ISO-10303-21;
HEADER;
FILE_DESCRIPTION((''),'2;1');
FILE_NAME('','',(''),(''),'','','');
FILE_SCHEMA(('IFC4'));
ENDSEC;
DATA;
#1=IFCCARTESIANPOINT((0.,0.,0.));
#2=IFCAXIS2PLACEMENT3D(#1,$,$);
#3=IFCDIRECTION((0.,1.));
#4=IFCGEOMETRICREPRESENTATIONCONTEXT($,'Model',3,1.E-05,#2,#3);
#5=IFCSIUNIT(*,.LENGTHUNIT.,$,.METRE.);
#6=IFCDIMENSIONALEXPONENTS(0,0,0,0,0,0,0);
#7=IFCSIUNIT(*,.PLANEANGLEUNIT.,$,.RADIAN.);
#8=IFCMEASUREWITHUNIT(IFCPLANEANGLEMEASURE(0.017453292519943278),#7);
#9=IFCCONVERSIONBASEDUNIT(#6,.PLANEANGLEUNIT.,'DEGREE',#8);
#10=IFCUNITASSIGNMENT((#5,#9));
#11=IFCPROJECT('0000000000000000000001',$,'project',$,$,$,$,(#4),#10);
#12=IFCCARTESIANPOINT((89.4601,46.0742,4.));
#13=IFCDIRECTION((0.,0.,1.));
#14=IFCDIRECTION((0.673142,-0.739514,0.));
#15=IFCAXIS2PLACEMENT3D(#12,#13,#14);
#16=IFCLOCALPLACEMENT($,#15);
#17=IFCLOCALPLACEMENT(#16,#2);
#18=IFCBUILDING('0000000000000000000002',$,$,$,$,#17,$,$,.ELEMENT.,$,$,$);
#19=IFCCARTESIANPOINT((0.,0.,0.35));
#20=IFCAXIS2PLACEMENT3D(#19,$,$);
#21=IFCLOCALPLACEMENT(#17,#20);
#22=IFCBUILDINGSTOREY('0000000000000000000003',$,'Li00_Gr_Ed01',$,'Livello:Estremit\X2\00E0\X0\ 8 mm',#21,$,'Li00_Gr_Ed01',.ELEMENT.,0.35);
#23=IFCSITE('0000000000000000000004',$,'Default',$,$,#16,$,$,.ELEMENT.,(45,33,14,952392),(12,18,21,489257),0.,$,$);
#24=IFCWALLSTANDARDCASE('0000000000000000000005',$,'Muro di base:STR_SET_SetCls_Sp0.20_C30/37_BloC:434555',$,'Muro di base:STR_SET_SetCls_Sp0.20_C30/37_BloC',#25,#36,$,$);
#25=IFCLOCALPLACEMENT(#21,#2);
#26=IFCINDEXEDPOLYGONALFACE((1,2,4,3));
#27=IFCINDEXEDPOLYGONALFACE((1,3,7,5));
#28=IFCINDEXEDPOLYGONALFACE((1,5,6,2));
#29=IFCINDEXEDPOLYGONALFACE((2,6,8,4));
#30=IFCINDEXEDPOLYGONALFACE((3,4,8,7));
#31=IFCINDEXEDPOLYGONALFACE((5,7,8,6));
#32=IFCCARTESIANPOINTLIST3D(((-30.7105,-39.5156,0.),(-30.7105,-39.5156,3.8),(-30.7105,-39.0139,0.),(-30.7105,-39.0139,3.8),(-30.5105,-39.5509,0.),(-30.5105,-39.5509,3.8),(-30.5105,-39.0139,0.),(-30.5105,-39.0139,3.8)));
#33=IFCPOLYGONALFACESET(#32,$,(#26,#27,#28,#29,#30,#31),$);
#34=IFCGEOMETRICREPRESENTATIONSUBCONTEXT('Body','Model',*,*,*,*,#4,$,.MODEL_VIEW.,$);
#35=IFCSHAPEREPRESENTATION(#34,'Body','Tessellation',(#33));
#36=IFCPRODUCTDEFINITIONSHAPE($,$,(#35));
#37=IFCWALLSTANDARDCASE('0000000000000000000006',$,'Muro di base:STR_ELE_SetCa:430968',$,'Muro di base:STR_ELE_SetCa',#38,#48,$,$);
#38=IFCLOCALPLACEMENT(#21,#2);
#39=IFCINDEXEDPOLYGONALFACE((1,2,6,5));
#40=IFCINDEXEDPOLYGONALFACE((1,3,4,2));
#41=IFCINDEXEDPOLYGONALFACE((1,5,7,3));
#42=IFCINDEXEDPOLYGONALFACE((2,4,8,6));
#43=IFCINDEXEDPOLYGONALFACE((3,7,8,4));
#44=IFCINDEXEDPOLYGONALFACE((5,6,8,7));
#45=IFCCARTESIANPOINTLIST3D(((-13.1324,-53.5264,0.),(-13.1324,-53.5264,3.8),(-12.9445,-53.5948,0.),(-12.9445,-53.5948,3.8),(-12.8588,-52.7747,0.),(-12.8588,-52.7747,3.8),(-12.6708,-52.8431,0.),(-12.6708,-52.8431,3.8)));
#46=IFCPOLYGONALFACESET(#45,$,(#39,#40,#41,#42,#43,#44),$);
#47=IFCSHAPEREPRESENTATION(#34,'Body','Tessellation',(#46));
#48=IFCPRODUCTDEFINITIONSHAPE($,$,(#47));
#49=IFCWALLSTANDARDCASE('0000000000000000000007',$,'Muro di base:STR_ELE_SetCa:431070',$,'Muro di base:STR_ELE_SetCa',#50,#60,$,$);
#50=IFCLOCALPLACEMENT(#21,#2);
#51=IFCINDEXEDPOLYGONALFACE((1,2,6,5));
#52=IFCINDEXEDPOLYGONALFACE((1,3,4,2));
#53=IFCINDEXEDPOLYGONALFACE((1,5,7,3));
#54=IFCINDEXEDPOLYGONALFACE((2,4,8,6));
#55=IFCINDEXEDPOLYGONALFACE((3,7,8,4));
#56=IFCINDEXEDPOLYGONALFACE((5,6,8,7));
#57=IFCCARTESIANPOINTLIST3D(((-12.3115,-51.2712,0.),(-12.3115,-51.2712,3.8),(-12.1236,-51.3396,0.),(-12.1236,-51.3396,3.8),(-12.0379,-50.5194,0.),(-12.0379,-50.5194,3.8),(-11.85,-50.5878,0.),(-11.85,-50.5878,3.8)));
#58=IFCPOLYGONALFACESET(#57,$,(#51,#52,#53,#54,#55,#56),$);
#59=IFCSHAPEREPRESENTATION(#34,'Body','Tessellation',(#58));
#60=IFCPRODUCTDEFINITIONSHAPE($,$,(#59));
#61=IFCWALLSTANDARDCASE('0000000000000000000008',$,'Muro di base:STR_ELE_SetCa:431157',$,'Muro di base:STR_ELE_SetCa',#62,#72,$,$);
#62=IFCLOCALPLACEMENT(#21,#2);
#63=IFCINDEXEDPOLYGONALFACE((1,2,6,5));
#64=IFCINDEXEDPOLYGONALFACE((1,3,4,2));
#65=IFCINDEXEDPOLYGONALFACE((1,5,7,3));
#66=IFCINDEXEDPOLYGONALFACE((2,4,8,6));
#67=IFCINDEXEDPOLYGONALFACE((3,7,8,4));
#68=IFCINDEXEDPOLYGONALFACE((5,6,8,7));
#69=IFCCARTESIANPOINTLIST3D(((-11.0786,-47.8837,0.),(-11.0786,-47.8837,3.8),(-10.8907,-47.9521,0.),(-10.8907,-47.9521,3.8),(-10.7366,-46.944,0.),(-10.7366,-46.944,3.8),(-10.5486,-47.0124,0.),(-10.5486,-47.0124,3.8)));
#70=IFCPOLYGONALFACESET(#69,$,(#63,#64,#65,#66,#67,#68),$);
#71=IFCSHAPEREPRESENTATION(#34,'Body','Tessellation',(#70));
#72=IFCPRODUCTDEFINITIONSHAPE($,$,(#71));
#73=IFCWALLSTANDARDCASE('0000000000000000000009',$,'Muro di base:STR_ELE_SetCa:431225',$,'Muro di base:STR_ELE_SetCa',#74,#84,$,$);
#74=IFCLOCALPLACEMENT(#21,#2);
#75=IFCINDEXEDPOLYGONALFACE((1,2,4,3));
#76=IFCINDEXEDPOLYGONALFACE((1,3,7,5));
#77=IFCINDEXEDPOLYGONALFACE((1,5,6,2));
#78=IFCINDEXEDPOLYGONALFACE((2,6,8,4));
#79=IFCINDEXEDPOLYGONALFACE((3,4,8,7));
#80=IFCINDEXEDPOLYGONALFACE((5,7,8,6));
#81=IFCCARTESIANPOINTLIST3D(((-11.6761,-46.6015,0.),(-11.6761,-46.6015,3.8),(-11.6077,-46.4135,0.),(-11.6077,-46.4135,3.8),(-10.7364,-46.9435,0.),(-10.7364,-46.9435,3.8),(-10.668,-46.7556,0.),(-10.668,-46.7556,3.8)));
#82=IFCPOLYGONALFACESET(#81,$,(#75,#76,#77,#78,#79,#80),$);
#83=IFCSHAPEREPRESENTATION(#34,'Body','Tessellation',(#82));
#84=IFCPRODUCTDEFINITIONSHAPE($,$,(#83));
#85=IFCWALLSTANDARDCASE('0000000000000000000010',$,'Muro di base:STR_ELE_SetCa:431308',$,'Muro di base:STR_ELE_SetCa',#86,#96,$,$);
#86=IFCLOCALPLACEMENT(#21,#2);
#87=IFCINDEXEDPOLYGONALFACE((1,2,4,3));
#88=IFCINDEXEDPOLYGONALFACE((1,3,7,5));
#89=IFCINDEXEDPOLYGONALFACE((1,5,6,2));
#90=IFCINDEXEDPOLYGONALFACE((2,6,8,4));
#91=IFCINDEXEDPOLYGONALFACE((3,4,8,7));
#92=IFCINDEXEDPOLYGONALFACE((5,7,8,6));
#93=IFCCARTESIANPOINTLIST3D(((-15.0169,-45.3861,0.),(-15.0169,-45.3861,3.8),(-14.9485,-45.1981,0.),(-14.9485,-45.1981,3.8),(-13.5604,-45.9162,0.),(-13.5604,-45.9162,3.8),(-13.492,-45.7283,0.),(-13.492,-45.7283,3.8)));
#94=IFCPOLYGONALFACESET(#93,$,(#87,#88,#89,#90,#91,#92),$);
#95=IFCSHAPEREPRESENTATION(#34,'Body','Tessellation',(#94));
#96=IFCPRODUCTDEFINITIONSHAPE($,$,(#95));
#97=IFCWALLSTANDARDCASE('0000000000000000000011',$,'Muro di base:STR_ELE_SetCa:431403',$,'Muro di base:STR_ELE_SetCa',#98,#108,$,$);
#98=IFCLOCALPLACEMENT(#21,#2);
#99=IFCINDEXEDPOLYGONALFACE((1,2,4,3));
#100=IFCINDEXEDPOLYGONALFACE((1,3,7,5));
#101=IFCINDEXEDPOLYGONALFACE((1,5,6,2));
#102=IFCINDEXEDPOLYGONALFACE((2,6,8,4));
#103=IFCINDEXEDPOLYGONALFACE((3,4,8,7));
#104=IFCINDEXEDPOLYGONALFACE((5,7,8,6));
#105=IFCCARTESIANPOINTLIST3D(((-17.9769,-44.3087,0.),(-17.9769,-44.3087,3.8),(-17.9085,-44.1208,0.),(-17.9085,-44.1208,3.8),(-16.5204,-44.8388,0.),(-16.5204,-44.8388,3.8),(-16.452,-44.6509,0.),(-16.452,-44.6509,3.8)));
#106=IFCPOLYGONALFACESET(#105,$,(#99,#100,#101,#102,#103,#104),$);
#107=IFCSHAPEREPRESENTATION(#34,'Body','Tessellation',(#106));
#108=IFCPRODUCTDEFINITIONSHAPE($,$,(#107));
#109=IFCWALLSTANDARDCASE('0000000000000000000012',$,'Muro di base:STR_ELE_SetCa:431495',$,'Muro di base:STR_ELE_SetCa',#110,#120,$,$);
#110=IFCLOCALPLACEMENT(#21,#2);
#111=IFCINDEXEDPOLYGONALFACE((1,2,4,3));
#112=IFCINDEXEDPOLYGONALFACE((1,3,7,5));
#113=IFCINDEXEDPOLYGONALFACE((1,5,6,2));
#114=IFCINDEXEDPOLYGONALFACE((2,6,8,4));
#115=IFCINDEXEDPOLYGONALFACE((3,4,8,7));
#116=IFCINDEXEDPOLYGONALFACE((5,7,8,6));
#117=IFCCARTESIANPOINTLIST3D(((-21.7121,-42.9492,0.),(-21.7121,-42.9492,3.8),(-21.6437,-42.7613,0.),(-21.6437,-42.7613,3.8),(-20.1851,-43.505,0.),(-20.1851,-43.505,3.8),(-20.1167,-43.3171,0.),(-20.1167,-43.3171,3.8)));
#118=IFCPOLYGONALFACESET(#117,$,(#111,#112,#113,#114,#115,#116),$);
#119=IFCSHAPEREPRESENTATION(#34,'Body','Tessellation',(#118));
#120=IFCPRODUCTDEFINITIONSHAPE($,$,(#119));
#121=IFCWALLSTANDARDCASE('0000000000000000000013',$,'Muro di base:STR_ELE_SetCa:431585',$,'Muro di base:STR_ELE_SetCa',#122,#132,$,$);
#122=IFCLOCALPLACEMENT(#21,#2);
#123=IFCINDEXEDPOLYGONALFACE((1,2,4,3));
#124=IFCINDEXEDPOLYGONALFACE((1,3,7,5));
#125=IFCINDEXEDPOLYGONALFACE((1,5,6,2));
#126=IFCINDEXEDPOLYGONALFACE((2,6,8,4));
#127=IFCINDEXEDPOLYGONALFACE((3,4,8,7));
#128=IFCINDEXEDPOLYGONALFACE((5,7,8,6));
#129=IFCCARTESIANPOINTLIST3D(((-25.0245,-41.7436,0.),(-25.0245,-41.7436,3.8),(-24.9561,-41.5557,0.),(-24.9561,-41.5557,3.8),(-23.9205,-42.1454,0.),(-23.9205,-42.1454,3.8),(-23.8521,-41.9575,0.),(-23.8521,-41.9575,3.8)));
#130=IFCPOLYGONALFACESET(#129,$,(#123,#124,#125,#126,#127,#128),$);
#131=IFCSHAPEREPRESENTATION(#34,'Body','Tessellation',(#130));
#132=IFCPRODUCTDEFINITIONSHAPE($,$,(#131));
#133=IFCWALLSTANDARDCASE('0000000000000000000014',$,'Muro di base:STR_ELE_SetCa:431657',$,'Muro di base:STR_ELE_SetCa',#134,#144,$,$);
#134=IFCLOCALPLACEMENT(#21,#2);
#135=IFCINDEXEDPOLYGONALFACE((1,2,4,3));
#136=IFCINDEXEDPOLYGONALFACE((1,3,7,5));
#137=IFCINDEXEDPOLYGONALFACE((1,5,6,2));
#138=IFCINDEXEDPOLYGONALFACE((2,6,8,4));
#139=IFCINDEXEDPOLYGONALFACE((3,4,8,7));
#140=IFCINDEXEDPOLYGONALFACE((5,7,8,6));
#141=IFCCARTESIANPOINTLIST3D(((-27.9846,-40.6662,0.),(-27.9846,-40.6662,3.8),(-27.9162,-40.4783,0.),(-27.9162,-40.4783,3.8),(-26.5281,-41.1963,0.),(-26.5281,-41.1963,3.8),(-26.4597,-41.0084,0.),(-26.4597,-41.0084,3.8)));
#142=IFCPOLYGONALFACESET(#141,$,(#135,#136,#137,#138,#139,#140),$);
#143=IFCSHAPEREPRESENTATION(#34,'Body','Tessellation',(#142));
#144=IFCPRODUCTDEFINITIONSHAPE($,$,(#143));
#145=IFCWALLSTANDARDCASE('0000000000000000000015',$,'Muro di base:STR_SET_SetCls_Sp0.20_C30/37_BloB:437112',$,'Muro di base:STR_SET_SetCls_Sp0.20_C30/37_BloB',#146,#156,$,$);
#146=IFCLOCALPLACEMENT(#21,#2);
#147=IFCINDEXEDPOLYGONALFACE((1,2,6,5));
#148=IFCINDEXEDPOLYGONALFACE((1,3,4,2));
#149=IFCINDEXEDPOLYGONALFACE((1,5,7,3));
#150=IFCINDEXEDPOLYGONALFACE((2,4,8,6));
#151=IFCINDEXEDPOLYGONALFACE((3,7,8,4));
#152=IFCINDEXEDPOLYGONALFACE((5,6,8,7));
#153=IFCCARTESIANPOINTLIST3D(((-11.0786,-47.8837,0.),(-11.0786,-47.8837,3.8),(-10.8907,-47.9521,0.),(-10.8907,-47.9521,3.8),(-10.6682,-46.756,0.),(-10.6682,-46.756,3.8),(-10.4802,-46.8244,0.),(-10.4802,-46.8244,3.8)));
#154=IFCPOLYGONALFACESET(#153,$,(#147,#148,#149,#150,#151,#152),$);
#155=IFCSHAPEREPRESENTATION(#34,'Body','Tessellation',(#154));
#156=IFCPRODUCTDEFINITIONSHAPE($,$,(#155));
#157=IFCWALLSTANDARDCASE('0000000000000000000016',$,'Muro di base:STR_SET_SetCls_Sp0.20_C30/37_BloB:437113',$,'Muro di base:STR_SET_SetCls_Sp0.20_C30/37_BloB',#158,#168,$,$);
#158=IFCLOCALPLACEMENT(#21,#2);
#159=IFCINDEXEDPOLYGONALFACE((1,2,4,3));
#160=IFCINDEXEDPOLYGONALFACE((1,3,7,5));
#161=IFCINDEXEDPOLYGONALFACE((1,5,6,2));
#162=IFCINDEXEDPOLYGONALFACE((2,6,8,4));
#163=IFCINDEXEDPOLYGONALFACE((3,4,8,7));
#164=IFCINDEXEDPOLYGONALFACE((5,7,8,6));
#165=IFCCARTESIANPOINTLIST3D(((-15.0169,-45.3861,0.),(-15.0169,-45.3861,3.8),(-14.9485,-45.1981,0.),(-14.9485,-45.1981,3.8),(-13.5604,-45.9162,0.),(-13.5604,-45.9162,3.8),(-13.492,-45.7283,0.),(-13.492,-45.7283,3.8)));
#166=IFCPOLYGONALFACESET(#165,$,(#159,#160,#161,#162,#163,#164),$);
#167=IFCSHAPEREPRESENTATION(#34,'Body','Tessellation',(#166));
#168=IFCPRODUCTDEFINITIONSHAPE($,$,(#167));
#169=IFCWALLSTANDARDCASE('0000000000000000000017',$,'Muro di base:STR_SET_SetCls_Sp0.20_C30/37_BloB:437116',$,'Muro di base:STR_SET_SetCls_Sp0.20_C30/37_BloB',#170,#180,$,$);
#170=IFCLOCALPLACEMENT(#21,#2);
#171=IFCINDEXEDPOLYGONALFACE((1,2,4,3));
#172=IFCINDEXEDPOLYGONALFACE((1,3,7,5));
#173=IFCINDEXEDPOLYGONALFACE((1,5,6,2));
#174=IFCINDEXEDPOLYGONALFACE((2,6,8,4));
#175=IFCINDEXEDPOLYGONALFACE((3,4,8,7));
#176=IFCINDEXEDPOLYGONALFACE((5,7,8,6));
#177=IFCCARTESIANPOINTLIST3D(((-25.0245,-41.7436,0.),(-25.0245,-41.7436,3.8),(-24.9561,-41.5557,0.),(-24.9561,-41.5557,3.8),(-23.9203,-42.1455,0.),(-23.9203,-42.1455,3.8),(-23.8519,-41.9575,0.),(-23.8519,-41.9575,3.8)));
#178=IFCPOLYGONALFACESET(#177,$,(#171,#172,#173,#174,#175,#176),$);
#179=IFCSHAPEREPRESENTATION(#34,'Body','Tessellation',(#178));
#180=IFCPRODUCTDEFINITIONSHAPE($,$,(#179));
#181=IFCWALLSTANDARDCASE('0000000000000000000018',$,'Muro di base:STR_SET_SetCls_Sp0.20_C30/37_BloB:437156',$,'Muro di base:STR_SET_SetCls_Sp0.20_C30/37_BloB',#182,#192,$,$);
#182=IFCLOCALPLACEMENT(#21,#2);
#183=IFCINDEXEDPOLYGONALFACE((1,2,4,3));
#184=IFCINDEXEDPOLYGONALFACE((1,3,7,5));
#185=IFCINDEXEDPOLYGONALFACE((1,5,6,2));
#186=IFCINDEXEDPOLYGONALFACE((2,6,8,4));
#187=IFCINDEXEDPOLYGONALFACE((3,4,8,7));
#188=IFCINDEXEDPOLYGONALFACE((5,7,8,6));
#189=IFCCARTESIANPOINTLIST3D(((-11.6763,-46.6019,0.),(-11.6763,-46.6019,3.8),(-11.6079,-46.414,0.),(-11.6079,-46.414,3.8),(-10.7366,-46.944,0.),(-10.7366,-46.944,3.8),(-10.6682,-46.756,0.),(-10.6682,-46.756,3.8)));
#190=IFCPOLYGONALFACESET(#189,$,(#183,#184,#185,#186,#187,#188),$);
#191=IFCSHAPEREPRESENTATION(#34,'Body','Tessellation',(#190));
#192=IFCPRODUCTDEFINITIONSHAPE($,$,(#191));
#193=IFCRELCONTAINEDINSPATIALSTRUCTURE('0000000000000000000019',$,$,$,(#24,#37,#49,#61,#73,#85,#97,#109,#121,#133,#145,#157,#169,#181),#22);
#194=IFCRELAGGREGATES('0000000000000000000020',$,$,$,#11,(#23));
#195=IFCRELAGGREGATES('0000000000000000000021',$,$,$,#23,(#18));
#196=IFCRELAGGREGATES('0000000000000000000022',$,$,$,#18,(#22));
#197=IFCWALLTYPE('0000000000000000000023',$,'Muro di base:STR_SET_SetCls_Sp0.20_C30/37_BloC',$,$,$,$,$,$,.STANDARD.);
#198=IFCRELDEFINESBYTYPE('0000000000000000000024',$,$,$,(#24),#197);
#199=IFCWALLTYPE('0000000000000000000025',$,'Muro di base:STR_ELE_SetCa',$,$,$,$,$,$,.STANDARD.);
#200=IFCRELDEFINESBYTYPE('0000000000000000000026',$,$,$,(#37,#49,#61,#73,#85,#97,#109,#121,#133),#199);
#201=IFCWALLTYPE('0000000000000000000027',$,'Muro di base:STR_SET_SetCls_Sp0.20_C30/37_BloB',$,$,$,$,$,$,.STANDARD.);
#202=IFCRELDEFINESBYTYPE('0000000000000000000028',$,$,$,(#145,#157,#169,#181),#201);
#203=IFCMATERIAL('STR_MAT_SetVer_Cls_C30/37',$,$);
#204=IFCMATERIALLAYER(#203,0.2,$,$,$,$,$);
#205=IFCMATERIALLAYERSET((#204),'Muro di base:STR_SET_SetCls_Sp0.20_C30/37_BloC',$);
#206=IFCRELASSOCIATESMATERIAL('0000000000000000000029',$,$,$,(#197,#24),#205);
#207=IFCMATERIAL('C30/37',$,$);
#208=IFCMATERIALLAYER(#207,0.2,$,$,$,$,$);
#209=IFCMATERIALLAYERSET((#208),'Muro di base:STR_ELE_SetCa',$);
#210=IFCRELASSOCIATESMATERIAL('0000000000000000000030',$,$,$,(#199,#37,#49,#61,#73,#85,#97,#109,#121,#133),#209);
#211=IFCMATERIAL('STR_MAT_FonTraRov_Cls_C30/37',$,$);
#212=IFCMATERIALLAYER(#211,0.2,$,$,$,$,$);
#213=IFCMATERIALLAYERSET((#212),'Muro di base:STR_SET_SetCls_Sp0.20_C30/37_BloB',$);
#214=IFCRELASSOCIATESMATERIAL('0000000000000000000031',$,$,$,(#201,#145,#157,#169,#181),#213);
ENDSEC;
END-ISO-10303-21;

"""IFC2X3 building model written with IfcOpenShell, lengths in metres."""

from ifc_helpers import new_model, entity, si_unit, converted_unit, direction, frame, frame_2d, origin, place, context, subcontext, project, spatial, polyline, rectangle, outline, extrude, material, layer, layer_set, layer_usage, type_object, element, save


model = new_model("IFC2X3")

# Units and contexts
model_context = context("Model", 3, precision=1e-05, world=origin(), true_north=direction((0.0, 1.0)))
body_context = subcontext(model_context, "Body", "Model", "MODEL_VIEW")
ifc_project = project(units=[si_unit("LENGTHUNIT", "METRE"), converted_unit("PLANEANGLEUNIT", "DEGREE", entity("IfcPlaneAngleMeasure", 0.017453292519943278), si_unit("PLANEANGLEUNIT", "RADIAN"), dimensions=[0, 0, 0, 0, 0, 0, 0])], contexts=[model_context])

# Site, building, storey
site_placement = place(None, frame((89.4601, 46.0742, 4.0), z_axis=(0.0, 0.0, 1.0), x_axis=(0.673142, -0.739514, 0.0)))
site = spatial("IfcSite", under=ifc_project, at=site_placement, Name="Default", CompositionType="ELEMENT", RefLatitude=(45, 33, 14, 952392), RefLongitude=(12, 18, 21, 489257), RefElevation=0.0)
building_placement = place(site_placement, origin())
building = spatial("IfcBuilding", under=site, at=building_placement, CompositionType="ELEMENT")
storey_placement = place(building_placement, frame((0.0, 0.0, 0.35)))
storey = spatial("IfcBuildingStorey", under=building, at=storey_placement, Name="Li00_Gr_Ed01", ObjectType="Livello:Estremità 8 mm", LongName="Li00_Gr_Ed01", CompositionType="ELEMENT", Elevation=0.35)

# Shared definitions
ifc_material_1 = material(Name="STR_MAT_FonTraRov_Cls_C30/37")
ifc_material_2 = material(Name="C30/37")

# Walls
ifc_material_3 = material(Name="STR_MAT_SetVer_Cls_C30/37")
ifc_layer_1 = layer(ifc_material_3, 0.2)
ifc_layer_set_1 = layer_set([ifc_layer_1], Name="Muro di base:STR_SET_SetCls_Sp0.20_C30/37_BloC")
ifc_layer_usage_1 = layer_usage(ifc_layer_set_1, "AXIS2", "NEGATIVE", 0.1)
wall_type_1 = type_object("IfcWallType", Name="Muro di base:STR_SET_SetCls_Sp0.20_C30/37_BloC", PredefinedType="STANDARD", material=ifc_layer_set_1)
wall_1_placement = place(storey_placement, frame((-30.6105, -39.0139, 0.0), z_axis=(0.0, 0.0, 1.0), x_axis=(0.0, -1.0, 0.0)))
element("IfcWallStandardCase", 1, at=wall_1_placement, inside=storey, type_object=wall_type_1, material=ifc_layer_usage_1, Name="Muro di base:STR_SET_SetCls_Sp0.20_C30/37_BloC:434555", ObjectType="Muro di base:STR_SET_SetCls_Sp0.20_C30/37_BloC", context=body_context, shape_type="SweptSolid", body=[
    extrude(outline(polyline([(0.5017, -0.1), (0.537, 0.1), (0.0, 0.1), (0.0, -0.1), (0.5017, -0.1)])), origin(), (0.0, 0.0, 1.0), 3.8),
])
ifc_layer_2 = layer(ifc_material_2, 0.2)
ifc_layer_set_2 = layer_set([ifc_layer_2], Name="Muro di base:STR_ELE_SetCa")
ifc_layer_usage_2 = layer_usage(ifc_layer_set_2, "AXIS2", "NEGATIVE", 0.1)
wall_type_2 = type_object("IfcWallType", Name="Muro di base:STR_ELE_SetCa", PredefinedType="STANDARD", material=ifc_layer_set_2)
wall_2_placement = place(storey_placement, frame((-13.0384, -53.5606, 0.0), z_axis=(0.0, 0.0, 1.0), x_axis=(0.34202, 0.939693, 0.0)))
element("IfcWallStandardCase", 2, at=wall_2_placement, inside=storey, type_object=wall_type_2, material=ifc_layer_usage_2, Name="Muro di base:STR_ELE_SetCa:430968", ObjectType="Muro di base:STR_ELE_SetCa", context=body_context, shape_type="SweptSolid", body=[
    extrude(rectangle(XDim=0.8, YDim=0.2, at=frame_2d((0.4, 0.0), x_axis=(-1.0, 0.0))), origin(), (0.0, 0.0, 1.0), 3.8),
])
wall_3_placement = place(storey_placement, frame((-12.2176, -51.3054, 0.0), z_axis=(0.0, 0.0, 1.0), x_axis=(0.34202, 0.939693, 0.0)))
element("IfcWallStandardCase", 3, at=wall_3_placement, inside=storey, type_object=wall_type_2, material=ifc_layer_usage_2, Name="Muro di base:STR_ELE_SetCa:431070", ObjectType="Muro di base:STR_ELE_SetCa", context=body_context, shape_type="SweptSolid", body=[
    extrude(rectangle(XDim=0.8, YDim=0.2, at=frame_2d((0.4, 0.0), x_axis=(-1.0, 0.0))), origin(), (0.0, 0.0, 1.0), 3.8),
])
wall_4_placement = place(storey_placement, frame((-10.9846, -47.9179, 0.0), z_axis=(0.0, 0.0, 1.0), x_axis=(0.34202, 0.939693, 0.0)))
element("IfcWallStandardCase", 4, at=wall_4_placement, inside=storey, type_object=wall_type_2, material=ifc_layer_usage_2, Name="Muro di base:STR_ELE_SetCa:431157", ObjectType="Muro di base:STR_ELE_SetCa", context=body_context, shape_type="SweptSolid", body=[
    extrude(rectangle(XDim=1.0, YDim=0.2, at=frame_2d((0.5, 0.0), x_axis=(-1.0, 0.0))), origin(), (0.0, 0.0, 1.0), 3.8),
])
wall_5_placement = place(storey_placement, frame((-10.7022, -46.8495, 0.0), z_axis=(0.0, 0.0, 1.0), x_axis=(-0.939693, 0.34202, 0.0)))
element("IfcWallStandardCase", 5, at=wall_5_placement, inside=storey, type_object=wall_type_2, material=ifc_layer_usage_2, Name="Muro di base:STR_ELE_SetCa:431225", ObjectType="Muro di base:STR_ELE_SetCa", context=body_context, shape_type="SweptSolid", body=[
    extrude(rectangle(XDim=1.0, YDim=0.2, at=frame_2d((0.5, 0.0), x_axis=(-1.0, 0.0))), origin(), (0.0, 0.0, 1.0), 3.8),
])
wall_6_placement = place(storey_placement, frame((-13.5262, -45.8222, 0.0), z_axis=(0.0, 0.0, 1.0), x_axis=(-0.939693, 0.34202, 0.0)))
element("IfcWallStandardCase", 6, at=wall_6_placement, inside=storey, type_object=wall_type_2, material=ifc_layer_usage_2, Name="Muro di base:STR_ELE_SetCa:431308", ObjectType="Muro di base:STR_ELE_SetCa", context=body_context, shape_type="SweptSolid", body=[
    extrude(rectangle(XDim=1.55, YDim=0.2, at=frame_2d((0.775, 0.0), x_axis=(-1.0, 0.0))), origin(), (0.0, 0.0, 1.0), 3.8),
])
wall_7_placement = place(storey_placement, frame((-16.4862, -44.7449, 0.0), z_axis=(0.0, 0.0, 1.0), x_axis=(-0.939693, 0.34202, 0.0)))
element("IfcWallStandardCase", 7, at=wall_7_placement, inside=storey, type_object=wall_type_2, material=ifc_layer_usage_2, Name="Muro di base:STR_ELE_SetCa:431403", ObjectType="Muro di base:STR_ELE_SetCa", context=body_context, shape_type="SweptSolid", body=[
    extrude(rectangle(XDim=1.55, YDim=0.2, at=frame_2d((0.775, 0.0), x_axis=(-1.0, 0.0))), origin(), (0.0, 0.0, 1.0), 3.8),
])
wall_8_placement = place(storey_placement, frame((-20.1509, -43.411, 0.0), z_axis=(0.0, 0.0, 1.0), x_axis=(-0.939693, 0.34202, 0.0)))
element("IfcWallStandardCase", 8, at=wall_8_placement, inside=storey, type_object=wall_type_2, material=ifc_layer_usage_2, Name="Muro di base:STR_ELE_SetCa:431495", ObjectType="Muro di base:STR_ELE_SetCa", context=body_context, shape_type="SweptSolid", body=[
    extrude(rectangle(XDim=1.625, YDim=0.2, at=frame_2d((0.8125, 0.0), x_axis=(-1.0, 0.0))), origin(), (0.0, 0.0, 1.0), 3.8),
])
wall_9_placement = place(storey_placement, frame((-23.8863, -42.0515, 0.0), z_axis=(0.0, 0.0, 1.0), x_axis=(-0.939693, 0.34202, 0.0)))
element("IfcWallStandardCase", 9, at=wall_9_placement, inside=storey, type_object=wall_type_2, material=ifc_layer_usage_2, Name="Muro di base:STR_ELE_SetCa:431585", ObjectType="Muro di base:STR_ELE_SetCa", context=body_context, shape_type="SweptSolid", body=[
    extrude(rectangle(XDim=1.1748, YDim=0.2, at=frame_2d((0.5874, 0.0), x_axis=(-1.0, 0.0))), origin(), (0.0, 0.0, 1.0), 3.8),
])
wall_10_placement = place(storey_placement, frame((-26.4939, -41.1024, 0.0), z_axis=(0.0, 0.0, 1.0), x_axis=(-0.939693, 0.34202, 0.0)))
element("IfcWallStandardCase", 10, at=wall_10_placement, inside=storey, type_object=wall_type_2, material=ifc_layer_usage_2, Name="Muro di base:STR_ELE_SetCa:431657", ObjectType="Muro di base:STR_ELE_SetCa", context=body_context, shape_type="SweptSolid", body=[
    extrude(rectangle(XDim=1.55, YDim=0.2, at=frame_2d((0.775, 0.0), x_axis=(-1.0, 0.0))), origin(), (0.0, 0.0, 1.0), 3.8),
])
ifc_layer_3 = layer(ifc_material_1, 0.2)
ifc_layer_set_3 = layer_set([ifc_layer_3], Name="Muro di base:STR_SET_SetCls_Sp0.20_C30/37_BloB")
ifc_layer_usage_3 = layer_usage(ifc_layer_set_3, "AXIS2", "NEGATIVE", 0.1)
wall_type_3 = type_object("IfcWallType", Name="Muro di base:STR_SET_SetCls_Sp0.20_C30/37_BloB", PredefinedType="STANDARD", material=ifc_layer_set_3)
wall_11_placement = place(storey_placement, frame((-10.9846, -47.9179, 0.0), z_axis=(0.0, 0.0, 1.0), x_axis=(0.34202, 0.939693, 0.0)))
element("IfcWallStandardCase", 11, at=wall_11_placement, inside=storey, type_object=wall_type_3, material=ifc_layer_usage_3, Name="Muro di base:STR_SET_SetCls_Sp0.20_C30/37_BloB:437112", ObjectType="Muro di base:STR_SET_SetCls_Sp0.20_C30/37_BloB", context=body_context, shape_type="SweptSolid", body=[
    extrude(rectangle(XDim=1.2, YDim=0.2, at=frame_2d((0.6, 0.0), x_axis=(-1.0, 0.0))), origin(), (0.0, 0.0, 1.0), 3.8),
])
wall_12_placement = place(storey_placement, frame((-13.5262, -45.8222, 0.0), z_axis=(0.0, 0.0, 1.0), x_axis=(-0.939693, 0.34202, 0.0)))
element("IfcWallStandardCase", 12, at=wall_12_placement, inside=storey, type_object=wall_type_3, material=ifc_layer_usage_3, Name="Muro di base:STR_SET_SetCls_Sp0.20_C30/37_BloB:437113", ObjectType="Muro di base:STR_SET_SetCls_Sp0.20_C30/37_BloB", context=body_context, shape_type="SweptSolid", body=[
    extrude(rectangle(XDim=1.55, YDim=0.2, at=frame_2d((0.775, 0.0), x_axis=(-1.0, 0.0))), origin(), (0.0, 0.0, 1.0), 3.8),
])
wall_13_placement = place(storey_placement, frame((-23.8861, -42.0515, 0.0), z_axis=(0.0, 0.0, 1.0), x_axis=(-0.939693, 0.34202, 0.0)))
element("IfcWallStandardCase", 13, at=wall_13_placement, inside=storey, type_object=wall_type_3, material=ifc_layer_usage_3, Name="Muro di base:STR_SET_SetCls_Sp0.20_C30/37_BloB:437116", ObjectType="Muro di base:STR_SET_SetCls_Sp0.20_C30/37_BloB", context=body_context, shape_type="SweptSolid", body=[
    extrude(rectangle(XDim=1.175, YDim=0.2, at=frame_2d((0.5875, 0.0), x_axis=(-1.0, 0.0))), origin(), (0.0, 0.0, 1.0), 3.8),
])
wall_14_placement = place(storey_placement, frame((-11.6421, -46.508, 0.0), z_axis=(0.0, 0.0, 1.0), x_axis=(0.939693, -0.34202, 0.0)))
element("IfcWallStandardCase", 14, at=wall_14_placement, inside=storey, type_object=wall_type_3, material=ifc_layer_usage_3, Name="Muro di base:STR_SET_SetCls_Sp0.20_C30/37_BloB:437156", ObjectType="Muro di base:STR_SET_SetCls_Sp0.20_C30/37_BloB", context=body_context, shape_type="SweptSolid", body=[
    extrude(rectangle(XDim=1.0, YDim=0.2, at=frame_2d((0.5, 0.0), x_axis=(-1.0, 0.0))), origin(), (0.0, 0.0, 1.0), 3.8),
])

save(model, "model.ifc")
